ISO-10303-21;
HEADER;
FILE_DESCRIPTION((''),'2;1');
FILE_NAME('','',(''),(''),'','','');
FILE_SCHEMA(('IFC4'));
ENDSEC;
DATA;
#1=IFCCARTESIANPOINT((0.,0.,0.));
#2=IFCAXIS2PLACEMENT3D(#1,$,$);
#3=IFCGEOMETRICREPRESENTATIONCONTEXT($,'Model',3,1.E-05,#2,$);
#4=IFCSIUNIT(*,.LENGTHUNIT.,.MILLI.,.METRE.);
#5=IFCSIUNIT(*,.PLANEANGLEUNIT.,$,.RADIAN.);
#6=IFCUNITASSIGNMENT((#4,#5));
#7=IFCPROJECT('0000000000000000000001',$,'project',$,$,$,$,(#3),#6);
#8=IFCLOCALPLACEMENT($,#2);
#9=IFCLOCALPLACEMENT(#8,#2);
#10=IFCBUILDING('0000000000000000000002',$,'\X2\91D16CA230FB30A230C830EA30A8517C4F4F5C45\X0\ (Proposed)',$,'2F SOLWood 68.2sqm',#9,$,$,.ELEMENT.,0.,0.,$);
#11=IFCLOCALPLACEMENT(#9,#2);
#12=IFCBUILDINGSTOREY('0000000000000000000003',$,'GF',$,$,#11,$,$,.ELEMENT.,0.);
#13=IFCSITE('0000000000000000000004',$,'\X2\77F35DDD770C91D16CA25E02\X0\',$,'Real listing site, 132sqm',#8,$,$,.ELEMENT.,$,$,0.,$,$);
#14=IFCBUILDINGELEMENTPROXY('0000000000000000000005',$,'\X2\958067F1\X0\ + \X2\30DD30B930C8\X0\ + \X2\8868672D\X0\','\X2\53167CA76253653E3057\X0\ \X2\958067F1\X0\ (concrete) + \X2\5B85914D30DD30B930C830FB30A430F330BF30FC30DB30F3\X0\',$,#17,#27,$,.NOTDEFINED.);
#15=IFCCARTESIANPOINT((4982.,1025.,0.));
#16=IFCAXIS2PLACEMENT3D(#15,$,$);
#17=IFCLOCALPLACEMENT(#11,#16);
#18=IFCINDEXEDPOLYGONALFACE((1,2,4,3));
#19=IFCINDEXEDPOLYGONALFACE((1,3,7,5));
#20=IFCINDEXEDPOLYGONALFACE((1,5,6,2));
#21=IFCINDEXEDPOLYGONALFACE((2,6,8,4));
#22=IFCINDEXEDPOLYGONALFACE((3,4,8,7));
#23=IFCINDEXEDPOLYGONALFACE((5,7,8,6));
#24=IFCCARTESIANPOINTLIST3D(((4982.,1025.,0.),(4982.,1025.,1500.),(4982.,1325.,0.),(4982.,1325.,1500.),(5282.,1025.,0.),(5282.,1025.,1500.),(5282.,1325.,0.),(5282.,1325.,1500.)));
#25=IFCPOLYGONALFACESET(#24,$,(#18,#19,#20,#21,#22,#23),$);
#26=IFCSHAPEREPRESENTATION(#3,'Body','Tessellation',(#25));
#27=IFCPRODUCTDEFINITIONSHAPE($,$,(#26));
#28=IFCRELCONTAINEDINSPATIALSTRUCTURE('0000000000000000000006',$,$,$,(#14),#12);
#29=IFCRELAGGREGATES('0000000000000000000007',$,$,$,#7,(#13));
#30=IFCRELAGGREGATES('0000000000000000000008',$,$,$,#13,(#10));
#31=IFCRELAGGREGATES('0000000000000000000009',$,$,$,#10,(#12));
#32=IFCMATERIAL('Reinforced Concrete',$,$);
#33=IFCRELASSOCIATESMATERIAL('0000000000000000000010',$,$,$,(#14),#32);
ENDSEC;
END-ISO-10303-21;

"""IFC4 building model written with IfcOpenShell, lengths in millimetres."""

from ifc_helpers import new_model, si_unit, frame, frame_2d, origin, place, context, project, spatial, rectangle, extrude, material, element, save


model = new_model("IFC4")

# Units and contexts
model_context = context("Model", 3, precision=1e-05, world=origin())
ifc_project = project(units=[si_unit("LENGTHUNIT", "METRE", prefix="MILLI"), si_unit("PLANEANGLEUNIT", "RADIAN")], contexts=[model_context])

# Site, building, storey
site_placement = place(None, origin())
site = spatial("IfcSite", under=ifc_project, at=site_placement, Name="石川県金沢市", ObjectType="Real listing site, 132sqm", CompositionType="ELEMENT", RefElevation=0.0)
building_placement = place(site_placement, origin())
building = spatial("IfcBuilding", under=site, at=building_placement, Name="金沢・アトリエ兼住居 (Proposed)", ObjectType="2F SOLWood 68.2sqm", CompositionType="ELEMENT", ElevationOfRefHeight=0.0, ElevationOfTerrain=0.0)
storey_placement = place(building_placement, origin())
storey = spatial("IfcBuildingStorey", under=building, at=storey_placement, Name="GF", CompositionType="ELEMENT", Elevation=0.0)

# Shared definitions
ifc_material_1 = material(Name="Reinforced Concrete")

# Building element proxy
proxy_placement = place(storey_placement, frame((4982.0, 1025.0, 0.0)))
element("IfcBuildingElementProxy", 1, at=proxy_placement, inside=storey, material=ifc_material_1, Name="門柱 + ポスト + 表札", Description="化粧打放し 門柱 (concrete) + 宅配ポスト・インターホン", PredefinedType="NOTDEFINED", context=model_context, shape_type="SweptSolid", body=[
    extrude(rectangle(XDim=300.0, YDim=300.0, at=frame_2d((150.0, 150.0))), frame((4982.0, 1025.0, 0.0)), (0.0, 0.0, 1.0), 1500.0),
])

save(model, "model.ifc")
